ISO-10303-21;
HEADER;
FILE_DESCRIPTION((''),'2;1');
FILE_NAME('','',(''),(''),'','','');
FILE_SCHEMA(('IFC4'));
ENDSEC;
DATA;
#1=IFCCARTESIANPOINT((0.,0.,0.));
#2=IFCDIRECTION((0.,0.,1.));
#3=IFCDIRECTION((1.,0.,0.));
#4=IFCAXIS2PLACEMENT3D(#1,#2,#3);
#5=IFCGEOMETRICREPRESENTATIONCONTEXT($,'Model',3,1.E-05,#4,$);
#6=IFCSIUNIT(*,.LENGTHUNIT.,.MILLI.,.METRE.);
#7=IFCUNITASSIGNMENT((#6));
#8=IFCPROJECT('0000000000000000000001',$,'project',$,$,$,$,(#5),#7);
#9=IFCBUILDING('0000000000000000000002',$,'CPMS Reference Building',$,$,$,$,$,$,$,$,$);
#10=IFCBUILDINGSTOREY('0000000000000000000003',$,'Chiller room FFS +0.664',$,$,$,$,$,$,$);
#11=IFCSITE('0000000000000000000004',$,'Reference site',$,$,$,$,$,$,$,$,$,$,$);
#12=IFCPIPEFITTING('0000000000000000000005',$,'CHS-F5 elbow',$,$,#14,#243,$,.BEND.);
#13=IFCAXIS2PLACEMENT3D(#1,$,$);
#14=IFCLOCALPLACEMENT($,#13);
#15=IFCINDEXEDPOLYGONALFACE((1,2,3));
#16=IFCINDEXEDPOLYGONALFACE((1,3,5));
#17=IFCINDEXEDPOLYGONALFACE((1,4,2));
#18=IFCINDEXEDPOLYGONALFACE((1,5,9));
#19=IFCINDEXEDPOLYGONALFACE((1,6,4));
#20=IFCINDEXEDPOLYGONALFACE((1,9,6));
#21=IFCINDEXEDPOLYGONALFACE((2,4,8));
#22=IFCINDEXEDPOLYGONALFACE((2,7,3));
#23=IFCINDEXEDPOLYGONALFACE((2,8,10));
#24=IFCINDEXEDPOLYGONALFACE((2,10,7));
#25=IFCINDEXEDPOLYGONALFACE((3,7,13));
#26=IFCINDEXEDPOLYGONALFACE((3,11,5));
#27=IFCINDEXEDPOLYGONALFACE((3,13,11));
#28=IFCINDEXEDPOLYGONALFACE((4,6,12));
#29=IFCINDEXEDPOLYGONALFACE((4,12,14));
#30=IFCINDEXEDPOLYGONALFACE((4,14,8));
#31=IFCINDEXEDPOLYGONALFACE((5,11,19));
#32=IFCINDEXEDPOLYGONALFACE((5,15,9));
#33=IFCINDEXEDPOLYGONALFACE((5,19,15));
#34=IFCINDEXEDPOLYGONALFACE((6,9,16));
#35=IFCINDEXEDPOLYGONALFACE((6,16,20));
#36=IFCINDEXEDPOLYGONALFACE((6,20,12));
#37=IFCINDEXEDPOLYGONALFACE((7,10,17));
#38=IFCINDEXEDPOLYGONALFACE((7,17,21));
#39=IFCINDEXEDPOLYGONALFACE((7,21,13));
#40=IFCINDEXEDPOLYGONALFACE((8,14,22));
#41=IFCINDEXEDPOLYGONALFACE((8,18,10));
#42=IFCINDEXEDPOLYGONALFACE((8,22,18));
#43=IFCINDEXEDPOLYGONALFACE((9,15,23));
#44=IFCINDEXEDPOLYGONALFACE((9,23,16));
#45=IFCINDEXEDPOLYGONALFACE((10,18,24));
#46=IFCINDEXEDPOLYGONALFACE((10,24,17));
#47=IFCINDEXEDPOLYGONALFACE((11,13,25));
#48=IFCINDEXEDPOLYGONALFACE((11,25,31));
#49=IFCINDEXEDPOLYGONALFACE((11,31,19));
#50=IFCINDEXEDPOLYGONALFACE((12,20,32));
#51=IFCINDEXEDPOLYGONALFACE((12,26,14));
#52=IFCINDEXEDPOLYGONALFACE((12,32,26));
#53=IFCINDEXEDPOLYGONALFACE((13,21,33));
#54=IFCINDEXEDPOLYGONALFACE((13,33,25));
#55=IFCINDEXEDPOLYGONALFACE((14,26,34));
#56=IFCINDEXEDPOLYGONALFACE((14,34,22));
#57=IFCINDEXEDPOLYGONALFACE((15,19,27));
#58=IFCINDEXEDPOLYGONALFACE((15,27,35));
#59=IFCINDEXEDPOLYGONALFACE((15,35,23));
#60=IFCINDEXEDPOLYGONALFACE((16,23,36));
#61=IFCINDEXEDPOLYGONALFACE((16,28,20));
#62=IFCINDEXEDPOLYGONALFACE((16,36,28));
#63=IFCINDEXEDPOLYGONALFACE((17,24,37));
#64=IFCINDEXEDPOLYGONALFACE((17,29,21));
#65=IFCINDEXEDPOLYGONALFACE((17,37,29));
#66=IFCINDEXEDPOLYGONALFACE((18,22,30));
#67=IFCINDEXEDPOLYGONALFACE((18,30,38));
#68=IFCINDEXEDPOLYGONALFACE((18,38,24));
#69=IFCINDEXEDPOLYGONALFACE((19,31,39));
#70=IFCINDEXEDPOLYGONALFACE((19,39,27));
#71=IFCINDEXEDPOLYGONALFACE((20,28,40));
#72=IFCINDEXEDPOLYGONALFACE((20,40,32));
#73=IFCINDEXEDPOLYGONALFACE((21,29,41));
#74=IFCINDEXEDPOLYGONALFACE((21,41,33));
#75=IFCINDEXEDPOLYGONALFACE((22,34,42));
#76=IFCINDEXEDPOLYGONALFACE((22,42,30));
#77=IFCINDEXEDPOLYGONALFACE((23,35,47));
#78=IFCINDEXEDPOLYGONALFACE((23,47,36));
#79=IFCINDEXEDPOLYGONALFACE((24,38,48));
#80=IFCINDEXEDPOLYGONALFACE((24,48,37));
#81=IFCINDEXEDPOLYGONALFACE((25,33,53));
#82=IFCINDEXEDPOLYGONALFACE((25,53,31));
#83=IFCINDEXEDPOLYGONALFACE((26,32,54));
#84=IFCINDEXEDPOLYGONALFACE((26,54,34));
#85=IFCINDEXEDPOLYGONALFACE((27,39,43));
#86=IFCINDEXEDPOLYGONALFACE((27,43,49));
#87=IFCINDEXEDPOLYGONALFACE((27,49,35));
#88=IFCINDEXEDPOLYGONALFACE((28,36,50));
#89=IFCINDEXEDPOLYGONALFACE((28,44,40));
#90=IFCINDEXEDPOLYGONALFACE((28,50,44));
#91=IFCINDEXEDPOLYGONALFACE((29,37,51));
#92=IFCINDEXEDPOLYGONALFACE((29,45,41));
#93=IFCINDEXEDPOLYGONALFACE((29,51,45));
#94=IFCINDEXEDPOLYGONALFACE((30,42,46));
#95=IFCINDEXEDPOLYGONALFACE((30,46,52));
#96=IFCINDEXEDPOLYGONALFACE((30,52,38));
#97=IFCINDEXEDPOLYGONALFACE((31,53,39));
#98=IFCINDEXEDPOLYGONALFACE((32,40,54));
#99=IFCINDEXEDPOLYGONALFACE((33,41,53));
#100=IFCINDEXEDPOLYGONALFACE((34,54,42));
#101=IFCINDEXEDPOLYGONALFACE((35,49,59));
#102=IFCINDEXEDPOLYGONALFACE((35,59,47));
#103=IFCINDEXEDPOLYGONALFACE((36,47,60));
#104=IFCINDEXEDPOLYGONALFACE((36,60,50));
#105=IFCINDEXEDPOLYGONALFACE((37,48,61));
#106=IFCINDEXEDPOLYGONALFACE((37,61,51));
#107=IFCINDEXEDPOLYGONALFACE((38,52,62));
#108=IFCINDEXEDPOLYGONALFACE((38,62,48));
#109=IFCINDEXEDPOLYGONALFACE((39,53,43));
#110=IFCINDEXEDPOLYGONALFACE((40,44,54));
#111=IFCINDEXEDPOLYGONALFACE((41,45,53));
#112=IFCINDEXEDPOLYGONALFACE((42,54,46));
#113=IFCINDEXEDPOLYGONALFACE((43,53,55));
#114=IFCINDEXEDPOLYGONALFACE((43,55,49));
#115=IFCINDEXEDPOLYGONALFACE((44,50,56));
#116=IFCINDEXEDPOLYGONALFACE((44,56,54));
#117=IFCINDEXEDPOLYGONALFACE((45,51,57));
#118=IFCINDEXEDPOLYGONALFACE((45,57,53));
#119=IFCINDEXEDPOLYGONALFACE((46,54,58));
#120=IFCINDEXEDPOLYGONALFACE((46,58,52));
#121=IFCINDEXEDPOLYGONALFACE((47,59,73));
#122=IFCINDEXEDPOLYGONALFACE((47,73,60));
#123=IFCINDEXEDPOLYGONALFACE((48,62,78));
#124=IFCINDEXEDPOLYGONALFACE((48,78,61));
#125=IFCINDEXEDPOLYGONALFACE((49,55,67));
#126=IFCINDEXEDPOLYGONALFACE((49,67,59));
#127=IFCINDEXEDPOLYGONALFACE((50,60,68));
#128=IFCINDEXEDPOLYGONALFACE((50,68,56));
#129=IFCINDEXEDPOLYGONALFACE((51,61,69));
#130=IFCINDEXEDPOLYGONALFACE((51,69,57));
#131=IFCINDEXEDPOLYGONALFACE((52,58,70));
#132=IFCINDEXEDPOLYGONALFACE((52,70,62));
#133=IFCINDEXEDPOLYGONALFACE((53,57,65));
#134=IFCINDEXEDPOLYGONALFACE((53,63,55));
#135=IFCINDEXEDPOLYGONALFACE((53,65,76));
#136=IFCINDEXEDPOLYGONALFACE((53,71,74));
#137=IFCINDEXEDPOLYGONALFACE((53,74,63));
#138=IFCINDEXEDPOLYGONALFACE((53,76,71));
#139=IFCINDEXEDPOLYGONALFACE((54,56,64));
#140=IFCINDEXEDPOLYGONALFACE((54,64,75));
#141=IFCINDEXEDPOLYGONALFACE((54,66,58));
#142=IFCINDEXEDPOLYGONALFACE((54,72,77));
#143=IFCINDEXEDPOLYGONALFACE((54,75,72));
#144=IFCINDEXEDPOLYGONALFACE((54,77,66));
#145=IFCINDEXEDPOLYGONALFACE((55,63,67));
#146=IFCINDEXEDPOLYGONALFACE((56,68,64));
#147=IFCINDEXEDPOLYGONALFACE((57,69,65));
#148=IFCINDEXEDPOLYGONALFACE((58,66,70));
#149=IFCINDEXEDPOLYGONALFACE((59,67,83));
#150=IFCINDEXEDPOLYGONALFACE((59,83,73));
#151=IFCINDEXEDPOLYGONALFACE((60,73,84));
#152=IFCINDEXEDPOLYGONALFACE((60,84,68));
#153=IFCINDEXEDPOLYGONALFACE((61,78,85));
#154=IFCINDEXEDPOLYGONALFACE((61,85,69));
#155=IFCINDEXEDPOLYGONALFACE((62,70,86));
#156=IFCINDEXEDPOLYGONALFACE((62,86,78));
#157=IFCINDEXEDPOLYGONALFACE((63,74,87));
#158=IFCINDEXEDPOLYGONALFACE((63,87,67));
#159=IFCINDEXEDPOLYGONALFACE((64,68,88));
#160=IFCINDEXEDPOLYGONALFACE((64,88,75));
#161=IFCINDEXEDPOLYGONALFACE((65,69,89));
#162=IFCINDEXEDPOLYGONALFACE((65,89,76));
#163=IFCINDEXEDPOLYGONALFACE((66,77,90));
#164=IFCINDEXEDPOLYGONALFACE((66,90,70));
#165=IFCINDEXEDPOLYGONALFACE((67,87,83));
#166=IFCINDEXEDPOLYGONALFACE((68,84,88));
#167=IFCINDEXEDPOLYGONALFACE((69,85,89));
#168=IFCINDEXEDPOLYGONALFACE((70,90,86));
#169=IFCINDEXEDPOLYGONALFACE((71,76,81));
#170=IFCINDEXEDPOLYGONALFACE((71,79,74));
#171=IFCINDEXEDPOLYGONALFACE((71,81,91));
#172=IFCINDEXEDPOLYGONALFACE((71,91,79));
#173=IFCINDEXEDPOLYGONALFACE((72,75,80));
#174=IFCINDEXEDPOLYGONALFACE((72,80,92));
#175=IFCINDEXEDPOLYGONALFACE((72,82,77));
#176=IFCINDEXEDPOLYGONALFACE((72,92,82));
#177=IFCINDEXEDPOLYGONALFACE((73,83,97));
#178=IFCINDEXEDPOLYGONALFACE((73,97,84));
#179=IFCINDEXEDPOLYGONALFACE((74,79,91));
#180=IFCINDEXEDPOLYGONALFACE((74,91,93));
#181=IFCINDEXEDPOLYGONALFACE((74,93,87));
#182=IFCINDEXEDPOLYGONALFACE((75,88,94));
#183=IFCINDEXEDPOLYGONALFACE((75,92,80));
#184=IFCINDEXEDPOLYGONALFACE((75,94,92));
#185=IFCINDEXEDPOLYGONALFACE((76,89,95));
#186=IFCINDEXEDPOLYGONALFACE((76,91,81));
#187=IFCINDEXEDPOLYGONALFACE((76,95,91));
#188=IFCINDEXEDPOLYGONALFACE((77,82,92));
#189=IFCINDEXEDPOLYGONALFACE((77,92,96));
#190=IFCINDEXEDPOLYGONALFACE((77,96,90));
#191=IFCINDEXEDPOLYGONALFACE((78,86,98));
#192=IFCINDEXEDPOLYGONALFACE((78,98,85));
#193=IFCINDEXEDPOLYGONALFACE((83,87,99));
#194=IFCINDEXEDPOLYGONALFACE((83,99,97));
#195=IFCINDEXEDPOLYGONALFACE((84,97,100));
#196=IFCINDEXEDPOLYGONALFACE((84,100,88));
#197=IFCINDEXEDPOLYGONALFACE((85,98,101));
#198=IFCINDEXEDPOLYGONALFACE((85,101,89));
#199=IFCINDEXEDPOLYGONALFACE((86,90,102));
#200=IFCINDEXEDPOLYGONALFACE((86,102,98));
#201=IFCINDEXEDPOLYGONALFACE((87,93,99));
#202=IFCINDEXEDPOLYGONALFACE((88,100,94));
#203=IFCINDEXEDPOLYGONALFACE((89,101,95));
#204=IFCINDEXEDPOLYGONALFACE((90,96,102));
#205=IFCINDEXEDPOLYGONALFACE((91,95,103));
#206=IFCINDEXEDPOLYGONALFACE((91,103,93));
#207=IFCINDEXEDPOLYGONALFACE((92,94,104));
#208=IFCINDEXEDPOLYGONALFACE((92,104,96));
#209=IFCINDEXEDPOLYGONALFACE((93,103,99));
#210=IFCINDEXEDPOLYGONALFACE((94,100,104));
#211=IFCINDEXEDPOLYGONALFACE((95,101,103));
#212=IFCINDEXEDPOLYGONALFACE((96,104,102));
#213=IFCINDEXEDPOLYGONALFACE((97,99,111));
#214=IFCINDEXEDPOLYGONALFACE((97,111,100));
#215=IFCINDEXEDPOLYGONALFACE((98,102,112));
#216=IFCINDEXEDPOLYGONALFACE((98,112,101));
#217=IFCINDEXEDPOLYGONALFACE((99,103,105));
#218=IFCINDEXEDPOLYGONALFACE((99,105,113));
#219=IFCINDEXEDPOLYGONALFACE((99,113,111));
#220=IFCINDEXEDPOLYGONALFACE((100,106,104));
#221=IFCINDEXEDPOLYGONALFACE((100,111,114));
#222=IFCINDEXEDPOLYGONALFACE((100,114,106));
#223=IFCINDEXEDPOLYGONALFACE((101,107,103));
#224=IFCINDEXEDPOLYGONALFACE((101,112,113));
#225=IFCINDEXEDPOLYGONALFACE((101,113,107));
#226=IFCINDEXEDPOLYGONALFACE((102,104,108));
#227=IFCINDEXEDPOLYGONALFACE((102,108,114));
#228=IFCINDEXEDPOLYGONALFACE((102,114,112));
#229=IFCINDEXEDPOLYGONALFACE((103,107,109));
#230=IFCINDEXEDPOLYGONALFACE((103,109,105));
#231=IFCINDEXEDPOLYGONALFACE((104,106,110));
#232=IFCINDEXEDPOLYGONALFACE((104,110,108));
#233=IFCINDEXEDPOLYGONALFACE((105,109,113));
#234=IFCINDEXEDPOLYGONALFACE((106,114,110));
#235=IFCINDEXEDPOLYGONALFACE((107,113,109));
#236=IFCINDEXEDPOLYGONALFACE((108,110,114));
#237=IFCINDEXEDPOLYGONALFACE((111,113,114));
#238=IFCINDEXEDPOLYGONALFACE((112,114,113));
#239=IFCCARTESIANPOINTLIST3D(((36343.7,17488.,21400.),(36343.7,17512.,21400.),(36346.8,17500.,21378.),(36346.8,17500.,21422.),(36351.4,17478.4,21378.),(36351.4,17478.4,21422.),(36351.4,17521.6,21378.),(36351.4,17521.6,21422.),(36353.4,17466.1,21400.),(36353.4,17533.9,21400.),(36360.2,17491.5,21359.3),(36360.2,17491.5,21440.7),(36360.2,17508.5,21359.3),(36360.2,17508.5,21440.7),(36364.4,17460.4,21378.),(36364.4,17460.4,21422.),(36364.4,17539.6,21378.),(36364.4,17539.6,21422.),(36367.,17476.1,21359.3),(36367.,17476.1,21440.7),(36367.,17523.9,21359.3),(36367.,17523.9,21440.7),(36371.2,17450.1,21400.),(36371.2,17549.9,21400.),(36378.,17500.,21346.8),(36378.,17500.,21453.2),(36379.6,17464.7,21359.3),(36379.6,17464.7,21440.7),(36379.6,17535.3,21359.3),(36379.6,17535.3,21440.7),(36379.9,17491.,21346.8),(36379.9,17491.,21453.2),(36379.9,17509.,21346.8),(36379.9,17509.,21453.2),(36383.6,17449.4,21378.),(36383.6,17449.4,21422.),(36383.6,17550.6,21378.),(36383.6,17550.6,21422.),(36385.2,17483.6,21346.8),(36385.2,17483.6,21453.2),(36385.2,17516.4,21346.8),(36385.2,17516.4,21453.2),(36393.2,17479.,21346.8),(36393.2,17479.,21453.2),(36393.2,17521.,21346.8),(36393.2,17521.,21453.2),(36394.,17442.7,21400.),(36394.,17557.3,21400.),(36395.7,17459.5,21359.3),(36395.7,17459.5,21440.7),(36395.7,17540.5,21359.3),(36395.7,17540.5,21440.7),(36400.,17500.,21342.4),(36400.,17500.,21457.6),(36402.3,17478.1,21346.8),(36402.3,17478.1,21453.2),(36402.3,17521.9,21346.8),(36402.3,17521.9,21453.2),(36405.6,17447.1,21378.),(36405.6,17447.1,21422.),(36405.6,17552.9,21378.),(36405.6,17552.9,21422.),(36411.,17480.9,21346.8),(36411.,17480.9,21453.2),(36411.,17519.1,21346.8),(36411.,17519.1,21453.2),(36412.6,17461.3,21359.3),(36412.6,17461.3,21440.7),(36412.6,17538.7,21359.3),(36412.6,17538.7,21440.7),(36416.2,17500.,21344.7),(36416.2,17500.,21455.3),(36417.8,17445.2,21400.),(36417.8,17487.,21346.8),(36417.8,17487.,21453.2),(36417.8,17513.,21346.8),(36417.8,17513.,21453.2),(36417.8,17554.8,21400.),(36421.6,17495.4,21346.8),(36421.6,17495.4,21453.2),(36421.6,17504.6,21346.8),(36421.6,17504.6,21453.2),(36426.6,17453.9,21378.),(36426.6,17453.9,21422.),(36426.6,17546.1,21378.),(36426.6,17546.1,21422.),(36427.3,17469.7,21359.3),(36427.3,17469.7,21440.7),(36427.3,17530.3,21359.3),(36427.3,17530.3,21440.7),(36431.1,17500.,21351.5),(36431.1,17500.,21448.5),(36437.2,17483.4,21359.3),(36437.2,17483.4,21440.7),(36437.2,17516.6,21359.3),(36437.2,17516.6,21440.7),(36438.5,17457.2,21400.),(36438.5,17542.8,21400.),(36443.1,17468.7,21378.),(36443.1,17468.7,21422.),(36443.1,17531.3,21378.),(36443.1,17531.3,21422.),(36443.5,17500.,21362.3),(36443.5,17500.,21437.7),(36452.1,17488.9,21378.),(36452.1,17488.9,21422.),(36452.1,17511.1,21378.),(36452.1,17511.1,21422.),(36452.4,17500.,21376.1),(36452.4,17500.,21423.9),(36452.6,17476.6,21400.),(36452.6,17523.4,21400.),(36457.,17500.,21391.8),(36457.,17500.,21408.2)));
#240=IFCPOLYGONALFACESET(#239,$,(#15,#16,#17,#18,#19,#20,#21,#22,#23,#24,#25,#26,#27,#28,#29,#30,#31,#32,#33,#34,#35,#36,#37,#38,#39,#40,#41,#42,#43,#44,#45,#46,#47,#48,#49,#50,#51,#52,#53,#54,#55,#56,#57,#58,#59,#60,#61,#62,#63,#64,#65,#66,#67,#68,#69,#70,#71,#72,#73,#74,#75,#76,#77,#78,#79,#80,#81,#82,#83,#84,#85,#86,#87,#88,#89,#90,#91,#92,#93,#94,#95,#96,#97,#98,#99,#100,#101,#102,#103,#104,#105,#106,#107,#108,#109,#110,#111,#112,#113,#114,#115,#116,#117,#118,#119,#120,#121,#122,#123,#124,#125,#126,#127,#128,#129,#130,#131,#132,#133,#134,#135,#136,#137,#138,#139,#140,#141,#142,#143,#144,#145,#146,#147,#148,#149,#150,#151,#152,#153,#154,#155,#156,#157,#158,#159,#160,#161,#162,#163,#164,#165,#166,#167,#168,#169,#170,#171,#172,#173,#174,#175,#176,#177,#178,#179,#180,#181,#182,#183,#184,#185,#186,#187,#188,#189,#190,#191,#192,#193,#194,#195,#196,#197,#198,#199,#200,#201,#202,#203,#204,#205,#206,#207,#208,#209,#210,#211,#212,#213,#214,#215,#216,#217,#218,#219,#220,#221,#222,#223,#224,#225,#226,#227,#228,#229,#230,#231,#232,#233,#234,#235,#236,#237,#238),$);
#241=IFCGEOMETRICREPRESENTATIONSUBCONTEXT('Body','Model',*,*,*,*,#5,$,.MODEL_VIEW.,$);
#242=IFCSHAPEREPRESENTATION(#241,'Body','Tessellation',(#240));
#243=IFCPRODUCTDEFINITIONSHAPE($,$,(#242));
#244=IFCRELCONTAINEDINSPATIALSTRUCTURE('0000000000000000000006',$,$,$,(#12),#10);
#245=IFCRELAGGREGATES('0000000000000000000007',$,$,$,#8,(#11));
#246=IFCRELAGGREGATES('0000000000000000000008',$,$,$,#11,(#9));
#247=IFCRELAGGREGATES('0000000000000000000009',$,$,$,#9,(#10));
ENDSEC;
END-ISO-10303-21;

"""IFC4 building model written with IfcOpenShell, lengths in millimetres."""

from ifc_helpers import new_model, entity, si_unit, origin_with_axes, place, context, subcontext, project, spatial, element, save


model = new_model("IFC4")

# Units and contexts
model_context = context("Model", 3, precision=1e-05, world=origin_with_axes())
body_context = subcontext(model_context, "Body", "Model", "MODEL_VIEW")
ifc_project = project(units=[si_unit("LENGTHUNIT", "METRE", prefix="MILLI")], contexts=[model_context])

# Site, building, storey
site = spatial("IfcSite", under=ifc_project, Name="Reference site")
building = spatial("IfcBuilding", under=site, Name="CPMS Reference Building")
storey = spatial("IfcBuildingStorey", under=building, Name="Chiller room FFS +0.664")

# Pipe fitting
pipe_fitting_1_placement = place(None, origin_with_axes())
element("IfcPipeFitting", 1, at=pipe_fitting_1_placement, inside=storey, Name="CHS-F5 elbow", PredefinedType="BEND", context=body_context, shape_type="CSG", body=[
    entity("IfcSphere", entity("IfcAxis2Placement3D", entity("IfcCartesianPoint", [36400.0, 17500.0, 21400.0]), entity("IfcDirection", [0.0, 0.0, 1.0]), entity("IfcDirection", [1.0, 0.0, 0.0])), 57.6),
])

save(model, "model.ifc")
